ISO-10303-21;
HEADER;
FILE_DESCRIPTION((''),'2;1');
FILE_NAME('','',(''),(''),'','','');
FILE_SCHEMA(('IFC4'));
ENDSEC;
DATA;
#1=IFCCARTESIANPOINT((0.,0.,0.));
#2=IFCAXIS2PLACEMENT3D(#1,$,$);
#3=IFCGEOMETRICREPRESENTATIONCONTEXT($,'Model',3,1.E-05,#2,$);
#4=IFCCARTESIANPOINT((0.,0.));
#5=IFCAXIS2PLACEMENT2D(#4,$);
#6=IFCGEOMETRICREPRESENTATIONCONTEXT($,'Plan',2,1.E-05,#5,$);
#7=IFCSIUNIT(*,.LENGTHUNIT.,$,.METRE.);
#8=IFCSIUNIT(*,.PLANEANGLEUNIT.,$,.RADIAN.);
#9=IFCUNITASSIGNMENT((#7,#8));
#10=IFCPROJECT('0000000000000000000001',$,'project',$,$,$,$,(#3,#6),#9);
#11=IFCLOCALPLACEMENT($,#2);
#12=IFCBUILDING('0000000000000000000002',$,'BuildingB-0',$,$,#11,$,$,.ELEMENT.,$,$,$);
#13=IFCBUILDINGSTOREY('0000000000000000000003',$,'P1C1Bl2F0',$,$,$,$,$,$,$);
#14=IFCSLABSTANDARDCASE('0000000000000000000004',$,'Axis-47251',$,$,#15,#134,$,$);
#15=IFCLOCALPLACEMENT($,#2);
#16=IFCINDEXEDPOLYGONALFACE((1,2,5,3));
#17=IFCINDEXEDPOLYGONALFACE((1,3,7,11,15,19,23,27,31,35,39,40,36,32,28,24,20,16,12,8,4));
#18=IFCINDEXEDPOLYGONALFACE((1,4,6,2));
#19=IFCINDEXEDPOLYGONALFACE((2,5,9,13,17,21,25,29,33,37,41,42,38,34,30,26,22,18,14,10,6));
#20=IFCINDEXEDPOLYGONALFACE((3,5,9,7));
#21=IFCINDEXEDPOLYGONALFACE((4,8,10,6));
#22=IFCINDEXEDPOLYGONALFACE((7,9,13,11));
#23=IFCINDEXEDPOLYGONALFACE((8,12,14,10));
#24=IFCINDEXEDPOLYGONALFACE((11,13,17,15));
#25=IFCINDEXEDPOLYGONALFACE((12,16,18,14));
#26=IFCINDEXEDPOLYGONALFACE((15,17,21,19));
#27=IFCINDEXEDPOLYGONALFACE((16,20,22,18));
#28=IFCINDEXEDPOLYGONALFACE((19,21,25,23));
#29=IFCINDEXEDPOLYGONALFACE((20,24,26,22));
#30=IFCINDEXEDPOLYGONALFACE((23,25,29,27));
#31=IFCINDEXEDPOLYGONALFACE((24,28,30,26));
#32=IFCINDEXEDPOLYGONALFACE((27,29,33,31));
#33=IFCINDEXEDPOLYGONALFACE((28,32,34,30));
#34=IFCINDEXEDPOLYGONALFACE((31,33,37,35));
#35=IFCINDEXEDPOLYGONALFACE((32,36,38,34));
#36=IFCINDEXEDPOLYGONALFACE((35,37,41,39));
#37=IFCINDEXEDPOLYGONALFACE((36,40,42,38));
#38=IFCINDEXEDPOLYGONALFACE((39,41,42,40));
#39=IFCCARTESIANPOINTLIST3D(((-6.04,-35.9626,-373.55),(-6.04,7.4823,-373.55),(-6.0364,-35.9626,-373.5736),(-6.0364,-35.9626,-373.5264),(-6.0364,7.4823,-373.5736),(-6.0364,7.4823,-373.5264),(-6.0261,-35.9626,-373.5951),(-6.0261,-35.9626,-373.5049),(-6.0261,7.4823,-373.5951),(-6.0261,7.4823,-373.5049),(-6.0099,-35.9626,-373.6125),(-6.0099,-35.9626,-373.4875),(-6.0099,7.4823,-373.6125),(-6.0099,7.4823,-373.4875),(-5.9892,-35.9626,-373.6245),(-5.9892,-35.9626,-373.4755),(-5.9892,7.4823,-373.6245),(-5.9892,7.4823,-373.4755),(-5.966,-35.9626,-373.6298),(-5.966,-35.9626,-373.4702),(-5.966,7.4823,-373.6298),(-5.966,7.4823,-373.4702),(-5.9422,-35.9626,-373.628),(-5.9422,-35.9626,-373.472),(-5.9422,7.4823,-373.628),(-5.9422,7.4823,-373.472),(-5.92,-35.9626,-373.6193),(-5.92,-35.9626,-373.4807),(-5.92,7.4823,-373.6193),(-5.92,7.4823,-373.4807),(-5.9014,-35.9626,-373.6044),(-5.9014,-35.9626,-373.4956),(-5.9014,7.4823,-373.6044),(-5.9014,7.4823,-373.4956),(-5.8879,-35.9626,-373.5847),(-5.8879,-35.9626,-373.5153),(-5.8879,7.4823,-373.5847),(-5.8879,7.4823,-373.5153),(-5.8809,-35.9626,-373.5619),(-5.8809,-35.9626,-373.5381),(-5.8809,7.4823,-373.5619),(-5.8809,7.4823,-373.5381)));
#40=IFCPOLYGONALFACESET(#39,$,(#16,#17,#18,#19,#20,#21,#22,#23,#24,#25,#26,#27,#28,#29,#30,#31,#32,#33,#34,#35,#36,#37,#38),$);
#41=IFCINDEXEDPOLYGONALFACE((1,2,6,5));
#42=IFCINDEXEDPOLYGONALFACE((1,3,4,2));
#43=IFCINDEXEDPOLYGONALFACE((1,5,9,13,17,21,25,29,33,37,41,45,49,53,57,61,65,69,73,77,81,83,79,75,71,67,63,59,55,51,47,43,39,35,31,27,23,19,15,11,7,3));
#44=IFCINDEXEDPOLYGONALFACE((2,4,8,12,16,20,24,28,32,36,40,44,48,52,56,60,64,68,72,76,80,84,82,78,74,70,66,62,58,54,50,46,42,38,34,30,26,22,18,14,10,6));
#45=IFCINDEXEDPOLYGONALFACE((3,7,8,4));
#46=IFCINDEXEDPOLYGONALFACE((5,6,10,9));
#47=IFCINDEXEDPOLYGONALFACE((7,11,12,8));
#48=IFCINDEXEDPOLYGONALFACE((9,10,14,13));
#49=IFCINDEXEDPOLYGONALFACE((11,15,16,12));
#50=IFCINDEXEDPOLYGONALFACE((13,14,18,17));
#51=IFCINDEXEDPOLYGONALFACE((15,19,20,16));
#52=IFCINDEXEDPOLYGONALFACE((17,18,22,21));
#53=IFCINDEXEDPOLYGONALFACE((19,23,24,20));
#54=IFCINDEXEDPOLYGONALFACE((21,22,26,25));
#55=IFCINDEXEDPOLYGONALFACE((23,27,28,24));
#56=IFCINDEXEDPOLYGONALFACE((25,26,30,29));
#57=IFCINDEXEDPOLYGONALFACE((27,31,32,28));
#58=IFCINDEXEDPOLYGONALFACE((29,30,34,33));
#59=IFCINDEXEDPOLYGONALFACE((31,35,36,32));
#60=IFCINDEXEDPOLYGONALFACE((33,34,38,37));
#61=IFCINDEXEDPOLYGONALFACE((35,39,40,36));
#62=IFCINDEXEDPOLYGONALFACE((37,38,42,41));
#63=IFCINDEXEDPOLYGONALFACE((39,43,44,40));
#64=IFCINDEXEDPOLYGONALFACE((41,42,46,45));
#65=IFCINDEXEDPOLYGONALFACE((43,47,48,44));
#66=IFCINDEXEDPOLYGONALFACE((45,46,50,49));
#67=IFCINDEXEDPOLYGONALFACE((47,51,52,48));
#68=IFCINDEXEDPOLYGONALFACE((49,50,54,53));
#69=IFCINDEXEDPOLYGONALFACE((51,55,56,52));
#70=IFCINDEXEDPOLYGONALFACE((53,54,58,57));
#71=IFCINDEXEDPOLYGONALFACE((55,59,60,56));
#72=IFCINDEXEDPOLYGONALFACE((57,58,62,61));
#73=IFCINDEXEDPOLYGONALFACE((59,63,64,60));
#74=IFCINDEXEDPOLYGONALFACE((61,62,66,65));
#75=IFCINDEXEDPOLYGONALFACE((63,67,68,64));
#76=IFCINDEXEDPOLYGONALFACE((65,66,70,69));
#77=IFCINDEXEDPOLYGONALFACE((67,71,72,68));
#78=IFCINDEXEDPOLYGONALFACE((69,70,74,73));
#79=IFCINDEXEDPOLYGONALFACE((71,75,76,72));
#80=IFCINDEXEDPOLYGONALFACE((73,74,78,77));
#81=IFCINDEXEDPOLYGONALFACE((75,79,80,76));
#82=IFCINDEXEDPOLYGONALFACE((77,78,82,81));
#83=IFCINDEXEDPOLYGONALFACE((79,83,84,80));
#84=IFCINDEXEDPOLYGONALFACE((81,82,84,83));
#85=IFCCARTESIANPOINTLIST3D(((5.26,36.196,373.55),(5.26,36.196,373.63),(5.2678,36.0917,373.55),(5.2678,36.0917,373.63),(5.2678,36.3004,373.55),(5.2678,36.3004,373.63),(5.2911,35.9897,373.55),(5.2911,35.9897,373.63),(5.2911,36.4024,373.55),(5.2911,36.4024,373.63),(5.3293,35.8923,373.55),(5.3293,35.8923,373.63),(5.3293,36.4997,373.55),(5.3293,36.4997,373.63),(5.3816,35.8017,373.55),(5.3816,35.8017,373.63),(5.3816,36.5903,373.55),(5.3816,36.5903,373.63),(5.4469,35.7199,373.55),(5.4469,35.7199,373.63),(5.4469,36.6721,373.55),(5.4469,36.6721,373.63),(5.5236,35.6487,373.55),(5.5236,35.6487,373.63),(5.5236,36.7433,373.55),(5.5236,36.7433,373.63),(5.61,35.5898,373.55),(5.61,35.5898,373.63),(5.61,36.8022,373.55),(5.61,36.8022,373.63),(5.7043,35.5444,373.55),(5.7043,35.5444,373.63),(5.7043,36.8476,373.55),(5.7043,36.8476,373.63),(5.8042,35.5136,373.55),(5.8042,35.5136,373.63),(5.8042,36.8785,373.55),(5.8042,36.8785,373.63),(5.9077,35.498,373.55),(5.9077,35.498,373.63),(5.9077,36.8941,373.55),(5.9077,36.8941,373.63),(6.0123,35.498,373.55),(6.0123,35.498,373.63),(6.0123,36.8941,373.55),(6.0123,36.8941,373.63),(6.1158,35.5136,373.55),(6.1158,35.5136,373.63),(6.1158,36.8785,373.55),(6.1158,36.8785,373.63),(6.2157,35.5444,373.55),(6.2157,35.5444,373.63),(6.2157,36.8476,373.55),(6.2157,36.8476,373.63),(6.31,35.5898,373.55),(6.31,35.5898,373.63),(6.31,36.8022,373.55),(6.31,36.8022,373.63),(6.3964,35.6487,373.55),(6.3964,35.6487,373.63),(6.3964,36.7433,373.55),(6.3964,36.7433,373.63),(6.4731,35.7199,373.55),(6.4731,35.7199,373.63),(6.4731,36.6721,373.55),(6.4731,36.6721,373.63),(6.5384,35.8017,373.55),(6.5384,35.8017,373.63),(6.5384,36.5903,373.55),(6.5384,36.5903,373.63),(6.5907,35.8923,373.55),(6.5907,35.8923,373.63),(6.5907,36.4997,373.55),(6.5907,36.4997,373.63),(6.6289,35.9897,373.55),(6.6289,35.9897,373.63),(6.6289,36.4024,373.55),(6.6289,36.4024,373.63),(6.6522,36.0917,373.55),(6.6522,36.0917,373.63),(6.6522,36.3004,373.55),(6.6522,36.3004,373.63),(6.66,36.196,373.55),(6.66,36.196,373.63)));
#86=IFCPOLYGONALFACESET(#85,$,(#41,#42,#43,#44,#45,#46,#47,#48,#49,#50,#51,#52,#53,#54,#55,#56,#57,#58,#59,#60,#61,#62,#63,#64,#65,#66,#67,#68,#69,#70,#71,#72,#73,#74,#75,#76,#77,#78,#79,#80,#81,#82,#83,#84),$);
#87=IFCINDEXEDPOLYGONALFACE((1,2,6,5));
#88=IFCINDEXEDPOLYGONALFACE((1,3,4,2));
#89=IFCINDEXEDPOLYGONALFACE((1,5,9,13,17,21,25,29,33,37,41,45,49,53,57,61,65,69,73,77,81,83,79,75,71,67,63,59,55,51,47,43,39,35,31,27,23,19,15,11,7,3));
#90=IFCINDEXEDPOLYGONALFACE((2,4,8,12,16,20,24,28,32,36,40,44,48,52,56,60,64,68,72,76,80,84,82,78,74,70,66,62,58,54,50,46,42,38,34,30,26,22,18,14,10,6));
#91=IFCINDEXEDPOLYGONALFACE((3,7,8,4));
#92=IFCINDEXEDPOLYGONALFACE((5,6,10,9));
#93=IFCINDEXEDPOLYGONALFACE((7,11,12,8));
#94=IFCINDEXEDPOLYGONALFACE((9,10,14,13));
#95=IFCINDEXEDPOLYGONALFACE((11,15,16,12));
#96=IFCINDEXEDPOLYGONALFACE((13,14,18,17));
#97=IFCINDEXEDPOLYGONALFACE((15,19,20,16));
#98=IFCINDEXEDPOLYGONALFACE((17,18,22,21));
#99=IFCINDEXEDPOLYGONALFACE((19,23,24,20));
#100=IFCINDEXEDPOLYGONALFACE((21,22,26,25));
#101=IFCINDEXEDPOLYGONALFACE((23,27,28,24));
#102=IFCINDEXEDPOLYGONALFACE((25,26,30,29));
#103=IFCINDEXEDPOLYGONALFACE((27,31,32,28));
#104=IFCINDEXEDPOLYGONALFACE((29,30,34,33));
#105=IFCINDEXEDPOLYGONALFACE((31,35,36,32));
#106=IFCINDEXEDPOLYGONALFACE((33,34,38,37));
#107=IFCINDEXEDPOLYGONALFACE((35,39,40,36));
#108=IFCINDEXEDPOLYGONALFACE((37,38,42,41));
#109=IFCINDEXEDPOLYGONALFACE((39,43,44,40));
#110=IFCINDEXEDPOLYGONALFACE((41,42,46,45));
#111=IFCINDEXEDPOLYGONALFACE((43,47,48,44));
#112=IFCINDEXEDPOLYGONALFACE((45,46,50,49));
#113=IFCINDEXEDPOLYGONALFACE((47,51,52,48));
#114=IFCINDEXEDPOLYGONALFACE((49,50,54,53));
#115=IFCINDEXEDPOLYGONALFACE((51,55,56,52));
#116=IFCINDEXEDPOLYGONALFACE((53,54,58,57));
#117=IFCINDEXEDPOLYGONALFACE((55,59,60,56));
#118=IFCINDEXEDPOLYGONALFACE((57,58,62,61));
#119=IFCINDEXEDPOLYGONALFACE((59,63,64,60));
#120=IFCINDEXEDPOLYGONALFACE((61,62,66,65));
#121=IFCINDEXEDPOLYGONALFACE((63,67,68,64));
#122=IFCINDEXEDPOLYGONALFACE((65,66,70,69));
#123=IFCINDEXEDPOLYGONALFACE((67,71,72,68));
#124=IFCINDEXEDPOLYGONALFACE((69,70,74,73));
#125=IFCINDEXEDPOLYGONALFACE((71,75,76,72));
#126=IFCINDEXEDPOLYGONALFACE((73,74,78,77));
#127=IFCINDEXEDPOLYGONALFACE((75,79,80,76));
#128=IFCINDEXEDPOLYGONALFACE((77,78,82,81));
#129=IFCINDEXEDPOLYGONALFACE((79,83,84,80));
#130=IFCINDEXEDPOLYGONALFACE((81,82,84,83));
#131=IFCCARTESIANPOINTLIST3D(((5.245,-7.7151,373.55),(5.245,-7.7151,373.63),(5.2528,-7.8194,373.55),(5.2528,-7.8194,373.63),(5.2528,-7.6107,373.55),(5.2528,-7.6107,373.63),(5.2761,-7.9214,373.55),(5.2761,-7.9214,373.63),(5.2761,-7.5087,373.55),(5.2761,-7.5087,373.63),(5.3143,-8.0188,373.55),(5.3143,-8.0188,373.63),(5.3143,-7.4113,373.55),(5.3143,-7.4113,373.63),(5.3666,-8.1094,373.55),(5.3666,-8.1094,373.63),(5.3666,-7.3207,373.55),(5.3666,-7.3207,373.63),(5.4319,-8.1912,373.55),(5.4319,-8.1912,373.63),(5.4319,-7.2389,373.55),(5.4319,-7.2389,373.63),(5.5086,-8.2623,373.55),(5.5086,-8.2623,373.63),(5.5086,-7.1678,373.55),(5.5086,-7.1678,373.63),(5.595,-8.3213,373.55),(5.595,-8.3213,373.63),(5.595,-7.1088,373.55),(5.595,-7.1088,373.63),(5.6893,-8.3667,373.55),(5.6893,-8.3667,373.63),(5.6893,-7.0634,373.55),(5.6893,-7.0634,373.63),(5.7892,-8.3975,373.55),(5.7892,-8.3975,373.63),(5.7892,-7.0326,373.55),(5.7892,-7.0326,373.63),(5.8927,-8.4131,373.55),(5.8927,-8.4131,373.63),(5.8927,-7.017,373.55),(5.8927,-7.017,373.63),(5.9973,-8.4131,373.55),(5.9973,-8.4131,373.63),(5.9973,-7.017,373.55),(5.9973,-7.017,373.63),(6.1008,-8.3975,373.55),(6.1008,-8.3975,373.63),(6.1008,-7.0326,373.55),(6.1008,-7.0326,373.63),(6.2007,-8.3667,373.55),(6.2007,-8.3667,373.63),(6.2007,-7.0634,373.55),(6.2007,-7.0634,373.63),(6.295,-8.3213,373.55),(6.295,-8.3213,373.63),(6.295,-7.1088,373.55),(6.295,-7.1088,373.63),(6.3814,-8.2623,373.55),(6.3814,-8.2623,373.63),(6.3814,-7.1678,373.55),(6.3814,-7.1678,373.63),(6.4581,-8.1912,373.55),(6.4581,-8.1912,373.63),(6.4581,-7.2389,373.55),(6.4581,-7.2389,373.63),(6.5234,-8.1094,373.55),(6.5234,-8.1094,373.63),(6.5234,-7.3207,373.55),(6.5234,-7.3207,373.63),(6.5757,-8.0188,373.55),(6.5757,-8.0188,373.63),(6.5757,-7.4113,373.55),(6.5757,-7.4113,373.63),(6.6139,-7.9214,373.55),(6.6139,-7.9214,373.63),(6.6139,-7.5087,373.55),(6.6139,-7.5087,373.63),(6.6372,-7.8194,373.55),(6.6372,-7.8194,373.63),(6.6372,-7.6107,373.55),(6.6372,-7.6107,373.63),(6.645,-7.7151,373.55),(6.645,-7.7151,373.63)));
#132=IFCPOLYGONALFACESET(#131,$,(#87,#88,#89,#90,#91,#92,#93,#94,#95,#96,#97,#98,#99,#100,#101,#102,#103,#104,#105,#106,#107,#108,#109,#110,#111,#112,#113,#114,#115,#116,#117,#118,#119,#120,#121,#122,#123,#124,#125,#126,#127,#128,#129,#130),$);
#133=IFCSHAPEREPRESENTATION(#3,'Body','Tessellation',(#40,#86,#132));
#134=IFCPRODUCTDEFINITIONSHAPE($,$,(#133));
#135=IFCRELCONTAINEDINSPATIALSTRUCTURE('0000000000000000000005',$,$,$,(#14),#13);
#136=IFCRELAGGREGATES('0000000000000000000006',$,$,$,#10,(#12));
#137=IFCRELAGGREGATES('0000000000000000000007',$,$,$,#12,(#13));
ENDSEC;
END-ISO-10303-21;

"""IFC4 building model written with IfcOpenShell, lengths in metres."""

from ifc_helpers import new_model, entity, si_unit, frame, origin, origin_2d, place, context, project, spatial, circle, extrude, element, save


model = new_model("IFC4")

# Units and contexts
model_context = context("Model", 3, precision=1e-05, world=origin())
plan_context = context("Plan", 2, precision=1e-05, world=origin_2d())
ifc_project = project(units=[si_unit("LENGTHUNIT", "METRE"), si_unit("PLANEANGLEUNIT", "RADIAN")], contexts=[model_context, plan_context])

# Building, storey
building_placement = place(None, origin())
building = spatial("IfcBuilding", under=ifc_project, at=building_placement, Name="BuildingB-0", CompositionType="ELEMENT")
storey = spatial("IfcBuildingStorey", under=building, Name="P1C1Bl2F0")

# Slab
element("IfcSlabStandardCase", 1, inside=storey, Name="Axis-47251", context=model_context, shape_type="AdvancedSweptSolid", body=[
    entity("IfcSurfaceCurveSweptAreaSolid", entity("IfcCircleProfileDef", "AREA", None, None, 0.08), None, entity("IfcPolyline", [entity("IfcCartesianPoint", [5.96, 35.9626, 373.55]), entity("IfcCartesianPoint", [5.96, -7.4823, 373.55])]), None, None, entity("IfcPlane", entity("IfcAxis2Placement3D", entity("IfcCartesianPoint", [5.96, 35.9626, 373.55]), entity("IfcDirection", [0.0, 0.0, 1.0]), entity("IfcDirection", [1.0, 0.0, 0.0])))),
    extrude(circle(Radius=0.7), frame((5.96, 36.196, 373.55)), (0.0, 0.0, 1.0), 0.08),
    extrude(circle(Radius=0.7), frame((5.945, -7.7151, 373.55)), (0.0, 0.0, 1.0), 0.08),
])

save(model, "model.ifc")
